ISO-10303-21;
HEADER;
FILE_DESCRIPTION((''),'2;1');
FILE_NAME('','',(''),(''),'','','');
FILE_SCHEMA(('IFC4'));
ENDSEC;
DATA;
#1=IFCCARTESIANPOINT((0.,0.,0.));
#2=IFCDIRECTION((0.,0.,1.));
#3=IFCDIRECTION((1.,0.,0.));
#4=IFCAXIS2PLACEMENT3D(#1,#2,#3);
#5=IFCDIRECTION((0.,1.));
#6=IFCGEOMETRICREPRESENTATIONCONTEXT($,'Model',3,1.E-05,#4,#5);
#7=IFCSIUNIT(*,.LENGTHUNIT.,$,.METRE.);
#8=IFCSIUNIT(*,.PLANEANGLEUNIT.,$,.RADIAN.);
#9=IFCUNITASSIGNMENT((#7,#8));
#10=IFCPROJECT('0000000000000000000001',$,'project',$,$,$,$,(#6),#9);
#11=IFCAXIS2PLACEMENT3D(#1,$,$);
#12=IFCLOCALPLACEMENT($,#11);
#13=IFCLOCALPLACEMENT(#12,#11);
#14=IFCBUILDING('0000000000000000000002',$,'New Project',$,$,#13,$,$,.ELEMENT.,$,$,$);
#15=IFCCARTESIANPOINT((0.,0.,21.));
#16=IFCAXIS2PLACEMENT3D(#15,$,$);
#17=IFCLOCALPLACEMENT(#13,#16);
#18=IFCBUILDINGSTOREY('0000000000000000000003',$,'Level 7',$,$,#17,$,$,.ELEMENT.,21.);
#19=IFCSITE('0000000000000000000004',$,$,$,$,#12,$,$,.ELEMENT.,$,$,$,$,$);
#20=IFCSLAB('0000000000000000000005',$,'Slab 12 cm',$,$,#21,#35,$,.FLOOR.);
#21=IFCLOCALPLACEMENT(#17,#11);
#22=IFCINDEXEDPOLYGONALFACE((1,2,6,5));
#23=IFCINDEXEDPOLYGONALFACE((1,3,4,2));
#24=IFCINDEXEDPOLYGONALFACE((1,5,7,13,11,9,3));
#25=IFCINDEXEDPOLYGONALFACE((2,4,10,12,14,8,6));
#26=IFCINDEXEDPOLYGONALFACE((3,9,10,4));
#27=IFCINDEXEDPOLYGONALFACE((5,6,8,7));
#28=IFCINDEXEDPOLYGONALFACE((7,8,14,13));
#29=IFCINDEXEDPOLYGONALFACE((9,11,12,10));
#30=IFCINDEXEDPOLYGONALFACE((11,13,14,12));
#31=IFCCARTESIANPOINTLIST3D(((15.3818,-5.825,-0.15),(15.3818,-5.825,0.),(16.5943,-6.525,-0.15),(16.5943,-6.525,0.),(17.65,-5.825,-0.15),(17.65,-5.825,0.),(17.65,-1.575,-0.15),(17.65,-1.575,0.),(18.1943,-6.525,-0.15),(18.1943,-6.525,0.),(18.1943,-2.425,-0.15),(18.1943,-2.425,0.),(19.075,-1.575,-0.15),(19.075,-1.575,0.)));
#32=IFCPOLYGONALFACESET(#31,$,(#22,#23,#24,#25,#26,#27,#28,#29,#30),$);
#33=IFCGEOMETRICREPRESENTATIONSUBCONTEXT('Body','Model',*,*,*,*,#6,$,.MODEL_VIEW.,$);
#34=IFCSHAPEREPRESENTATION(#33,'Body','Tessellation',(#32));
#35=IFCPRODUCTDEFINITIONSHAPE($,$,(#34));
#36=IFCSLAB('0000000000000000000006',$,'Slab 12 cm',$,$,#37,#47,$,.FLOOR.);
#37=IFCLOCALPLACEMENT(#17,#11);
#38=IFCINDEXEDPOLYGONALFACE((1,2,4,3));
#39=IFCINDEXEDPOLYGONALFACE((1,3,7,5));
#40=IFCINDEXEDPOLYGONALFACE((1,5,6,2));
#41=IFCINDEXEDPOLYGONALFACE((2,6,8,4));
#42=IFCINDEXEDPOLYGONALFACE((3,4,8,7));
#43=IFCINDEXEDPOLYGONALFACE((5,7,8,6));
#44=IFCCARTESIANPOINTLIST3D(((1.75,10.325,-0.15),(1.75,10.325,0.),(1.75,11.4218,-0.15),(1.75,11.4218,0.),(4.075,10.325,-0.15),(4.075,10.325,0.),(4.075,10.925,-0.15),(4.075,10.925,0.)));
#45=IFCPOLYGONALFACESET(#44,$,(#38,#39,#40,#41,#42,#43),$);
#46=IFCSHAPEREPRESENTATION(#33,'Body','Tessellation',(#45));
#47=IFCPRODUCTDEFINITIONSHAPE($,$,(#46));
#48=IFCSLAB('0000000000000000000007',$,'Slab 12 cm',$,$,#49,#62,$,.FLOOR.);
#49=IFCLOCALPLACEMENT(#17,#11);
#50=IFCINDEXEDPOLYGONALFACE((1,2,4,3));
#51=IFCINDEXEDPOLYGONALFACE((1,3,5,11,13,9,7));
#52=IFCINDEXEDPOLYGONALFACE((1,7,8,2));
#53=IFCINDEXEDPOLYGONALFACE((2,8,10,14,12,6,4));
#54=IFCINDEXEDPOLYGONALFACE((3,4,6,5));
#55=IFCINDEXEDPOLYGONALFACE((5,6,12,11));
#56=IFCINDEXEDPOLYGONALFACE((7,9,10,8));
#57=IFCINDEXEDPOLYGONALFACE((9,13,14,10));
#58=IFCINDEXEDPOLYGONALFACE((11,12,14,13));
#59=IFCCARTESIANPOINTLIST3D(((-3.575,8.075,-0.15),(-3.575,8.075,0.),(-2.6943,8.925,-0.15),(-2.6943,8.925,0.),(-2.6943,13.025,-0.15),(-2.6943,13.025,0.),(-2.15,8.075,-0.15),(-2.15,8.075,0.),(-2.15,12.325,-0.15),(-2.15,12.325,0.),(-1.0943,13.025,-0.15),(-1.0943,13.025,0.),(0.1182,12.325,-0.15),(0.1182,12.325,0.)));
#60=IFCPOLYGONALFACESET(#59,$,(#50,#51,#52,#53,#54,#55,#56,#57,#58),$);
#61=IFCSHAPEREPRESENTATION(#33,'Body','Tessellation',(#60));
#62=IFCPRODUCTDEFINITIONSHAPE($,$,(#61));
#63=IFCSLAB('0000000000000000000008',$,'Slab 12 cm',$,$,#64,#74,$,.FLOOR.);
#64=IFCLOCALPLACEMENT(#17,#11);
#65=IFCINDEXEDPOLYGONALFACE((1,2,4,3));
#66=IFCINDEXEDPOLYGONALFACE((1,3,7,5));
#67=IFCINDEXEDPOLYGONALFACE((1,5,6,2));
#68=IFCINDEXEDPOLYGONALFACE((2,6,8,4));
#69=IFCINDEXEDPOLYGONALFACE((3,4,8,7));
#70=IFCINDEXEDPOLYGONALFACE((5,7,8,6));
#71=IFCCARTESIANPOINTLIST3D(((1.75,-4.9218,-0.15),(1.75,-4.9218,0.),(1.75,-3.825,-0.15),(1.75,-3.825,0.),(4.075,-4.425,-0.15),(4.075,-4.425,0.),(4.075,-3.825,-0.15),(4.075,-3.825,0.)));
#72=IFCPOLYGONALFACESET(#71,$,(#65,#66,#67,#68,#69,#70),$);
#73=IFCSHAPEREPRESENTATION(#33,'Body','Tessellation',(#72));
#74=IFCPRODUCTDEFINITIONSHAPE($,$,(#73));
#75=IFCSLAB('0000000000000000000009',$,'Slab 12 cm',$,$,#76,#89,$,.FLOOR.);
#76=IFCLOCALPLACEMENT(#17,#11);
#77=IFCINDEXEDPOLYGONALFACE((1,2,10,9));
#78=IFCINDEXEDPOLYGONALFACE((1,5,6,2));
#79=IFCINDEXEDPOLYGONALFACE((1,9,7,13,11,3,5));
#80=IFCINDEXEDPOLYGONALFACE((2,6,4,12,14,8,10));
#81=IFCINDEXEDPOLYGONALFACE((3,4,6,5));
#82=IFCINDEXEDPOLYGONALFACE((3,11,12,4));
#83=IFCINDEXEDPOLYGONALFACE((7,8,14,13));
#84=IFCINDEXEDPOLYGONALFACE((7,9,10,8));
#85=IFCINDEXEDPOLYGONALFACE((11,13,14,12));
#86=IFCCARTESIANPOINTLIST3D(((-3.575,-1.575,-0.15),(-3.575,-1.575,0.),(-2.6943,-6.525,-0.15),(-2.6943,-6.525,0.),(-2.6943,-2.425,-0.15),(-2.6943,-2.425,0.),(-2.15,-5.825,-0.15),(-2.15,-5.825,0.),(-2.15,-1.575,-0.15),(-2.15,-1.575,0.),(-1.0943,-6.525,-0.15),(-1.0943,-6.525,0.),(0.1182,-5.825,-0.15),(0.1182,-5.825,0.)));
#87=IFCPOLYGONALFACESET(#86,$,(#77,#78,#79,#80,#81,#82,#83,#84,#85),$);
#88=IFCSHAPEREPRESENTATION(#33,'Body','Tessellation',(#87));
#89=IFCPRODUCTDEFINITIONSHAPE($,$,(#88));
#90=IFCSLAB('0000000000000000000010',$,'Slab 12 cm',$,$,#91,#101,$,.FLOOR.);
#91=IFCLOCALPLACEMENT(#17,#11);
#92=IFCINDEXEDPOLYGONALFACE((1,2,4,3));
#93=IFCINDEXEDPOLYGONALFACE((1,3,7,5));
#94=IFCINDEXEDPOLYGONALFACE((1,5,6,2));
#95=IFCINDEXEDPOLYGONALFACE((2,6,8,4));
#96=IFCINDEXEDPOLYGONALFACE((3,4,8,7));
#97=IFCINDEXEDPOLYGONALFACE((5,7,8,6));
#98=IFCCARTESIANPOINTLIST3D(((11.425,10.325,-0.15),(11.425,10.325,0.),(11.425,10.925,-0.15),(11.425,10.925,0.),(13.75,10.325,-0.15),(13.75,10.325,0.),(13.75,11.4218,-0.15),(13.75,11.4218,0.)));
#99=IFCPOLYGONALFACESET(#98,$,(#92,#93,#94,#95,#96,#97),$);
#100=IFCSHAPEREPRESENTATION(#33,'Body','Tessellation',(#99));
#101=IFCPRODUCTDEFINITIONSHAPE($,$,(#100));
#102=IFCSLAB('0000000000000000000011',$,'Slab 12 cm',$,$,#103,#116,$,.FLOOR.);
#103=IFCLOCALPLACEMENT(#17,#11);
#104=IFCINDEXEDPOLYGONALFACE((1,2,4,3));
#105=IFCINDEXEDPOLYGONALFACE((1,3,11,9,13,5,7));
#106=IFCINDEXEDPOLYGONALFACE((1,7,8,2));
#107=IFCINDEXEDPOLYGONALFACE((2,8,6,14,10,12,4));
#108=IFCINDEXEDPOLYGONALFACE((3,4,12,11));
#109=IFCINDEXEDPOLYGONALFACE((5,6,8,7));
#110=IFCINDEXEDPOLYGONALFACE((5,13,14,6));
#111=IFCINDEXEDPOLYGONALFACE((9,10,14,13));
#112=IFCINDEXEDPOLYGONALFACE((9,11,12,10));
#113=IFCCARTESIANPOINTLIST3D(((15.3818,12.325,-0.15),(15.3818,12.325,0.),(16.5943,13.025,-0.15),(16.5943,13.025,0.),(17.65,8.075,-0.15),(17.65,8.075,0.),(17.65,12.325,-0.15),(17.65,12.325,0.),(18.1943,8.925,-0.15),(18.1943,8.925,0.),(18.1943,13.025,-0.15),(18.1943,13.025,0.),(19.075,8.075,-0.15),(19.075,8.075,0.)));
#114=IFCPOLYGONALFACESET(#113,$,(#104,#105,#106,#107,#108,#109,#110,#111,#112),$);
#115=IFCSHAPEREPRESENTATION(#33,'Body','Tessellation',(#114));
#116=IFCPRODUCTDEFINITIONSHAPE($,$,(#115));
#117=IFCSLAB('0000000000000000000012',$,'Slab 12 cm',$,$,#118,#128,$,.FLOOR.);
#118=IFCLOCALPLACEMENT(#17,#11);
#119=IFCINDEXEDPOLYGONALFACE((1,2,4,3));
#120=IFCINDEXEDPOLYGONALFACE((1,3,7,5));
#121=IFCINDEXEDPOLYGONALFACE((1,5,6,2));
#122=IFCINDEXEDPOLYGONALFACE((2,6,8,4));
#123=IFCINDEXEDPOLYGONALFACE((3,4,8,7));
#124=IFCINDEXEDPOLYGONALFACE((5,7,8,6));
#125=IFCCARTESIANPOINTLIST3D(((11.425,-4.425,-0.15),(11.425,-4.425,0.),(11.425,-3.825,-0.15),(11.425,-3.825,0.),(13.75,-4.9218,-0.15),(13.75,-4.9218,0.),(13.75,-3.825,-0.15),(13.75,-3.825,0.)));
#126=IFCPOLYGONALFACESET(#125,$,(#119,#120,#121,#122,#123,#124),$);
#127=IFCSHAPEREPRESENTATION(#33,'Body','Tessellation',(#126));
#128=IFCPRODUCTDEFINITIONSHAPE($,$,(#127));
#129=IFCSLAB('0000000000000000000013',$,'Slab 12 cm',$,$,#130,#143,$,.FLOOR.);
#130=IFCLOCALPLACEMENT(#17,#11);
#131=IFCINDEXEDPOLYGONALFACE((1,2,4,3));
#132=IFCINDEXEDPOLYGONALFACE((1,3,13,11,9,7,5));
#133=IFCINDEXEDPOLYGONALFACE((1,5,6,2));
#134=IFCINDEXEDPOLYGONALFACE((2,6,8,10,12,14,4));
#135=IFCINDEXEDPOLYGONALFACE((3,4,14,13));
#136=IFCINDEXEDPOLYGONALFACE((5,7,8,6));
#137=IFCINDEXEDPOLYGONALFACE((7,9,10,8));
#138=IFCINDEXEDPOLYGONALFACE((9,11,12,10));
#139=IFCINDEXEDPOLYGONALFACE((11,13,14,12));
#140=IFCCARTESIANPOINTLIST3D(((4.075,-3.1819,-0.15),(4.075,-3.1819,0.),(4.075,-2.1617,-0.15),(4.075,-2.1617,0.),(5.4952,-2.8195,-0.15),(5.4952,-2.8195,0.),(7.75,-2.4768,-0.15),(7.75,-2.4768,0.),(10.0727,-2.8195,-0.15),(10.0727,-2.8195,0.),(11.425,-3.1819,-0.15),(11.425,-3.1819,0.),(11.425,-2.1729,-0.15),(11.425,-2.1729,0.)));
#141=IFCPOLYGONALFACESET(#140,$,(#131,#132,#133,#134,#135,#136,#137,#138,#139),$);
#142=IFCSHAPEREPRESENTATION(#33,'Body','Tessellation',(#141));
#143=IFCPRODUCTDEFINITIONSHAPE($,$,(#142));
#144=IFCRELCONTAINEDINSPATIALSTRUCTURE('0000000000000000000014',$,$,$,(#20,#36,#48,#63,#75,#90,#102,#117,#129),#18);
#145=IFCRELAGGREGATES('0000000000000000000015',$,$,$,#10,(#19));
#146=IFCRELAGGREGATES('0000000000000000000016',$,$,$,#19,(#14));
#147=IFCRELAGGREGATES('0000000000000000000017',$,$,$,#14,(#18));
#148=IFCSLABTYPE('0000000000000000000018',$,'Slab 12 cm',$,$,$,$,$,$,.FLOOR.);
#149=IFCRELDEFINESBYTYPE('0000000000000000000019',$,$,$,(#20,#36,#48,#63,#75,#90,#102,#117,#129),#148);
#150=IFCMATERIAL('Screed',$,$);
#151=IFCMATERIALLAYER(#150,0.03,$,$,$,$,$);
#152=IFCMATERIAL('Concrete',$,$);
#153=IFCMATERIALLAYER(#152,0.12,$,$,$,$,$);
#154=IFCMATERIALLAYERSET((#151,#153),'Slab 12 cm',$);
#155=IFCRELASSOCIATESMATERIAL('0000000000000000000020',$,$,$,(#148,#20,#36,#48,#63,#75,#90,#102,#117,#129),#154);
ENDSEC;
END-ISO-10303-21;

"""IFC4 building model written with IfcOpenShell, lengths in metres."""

from ifc_helpers import new_model, si_unit, direction, frame, origin, origin_with_axes, place, context, subcontext, project, spatial, polyline, outline, extrude, material, layer, layer_set, layer_usage, type_object, element, save


model = new_model("IFC4")

# Units and contexts
model_context = context("Model", 3, precision=1e-05, world=origin_with_axes(), true_north=direction((0.0, 1.0)))
body_context = subcontext(model_context, "Body", "Model", "MODEL_VIEW")
ifc_project = project(units=[si_unit("LENGTHUNIT", "METRE"), si_unit("PLANEANGLEUNIT", "RADIAN")], contexts=[model_context])

# Site, building, storey
site_placement = place(None, origin())
site = spatial("IfcSite", under=ifc_project, at=site_placement, CompositionType="ELEMENT")
building_placement = place(site_placement, origin())
building = spatial("IfcBuilding", under=site, at=building_placement, Name="New Project", CompositionType="ELEMENT")
storey_placement = place(building_placement, frame((0.0, 0.0, 21.0)))
storey = spatial("IfcBuildingStorey", under=building, at=storey_placement, Name="Level 7", CompositionType="ELEMENT", Elevation=21.0)

# Slabs
ifc_material_1 = material(Name="Screed")
ifc_layer_1 = layer(ifc_material_1, 0.03)
ifc_material_2 = material(Name="Concrete")
ifc_layer_2 = layer(ifc_material_2, 0.12)
ifc_layer_set_1 = layer_set([ifc_layer_1, ifc_layer_2], Name="Slab 12 cm")
ifc_layer_usage_1 = layer_usage(ifc_layer_set_1, "AXIS3", "NEGATIVE", 0.15)
slab_type = type_object("IfcSlabType", Name="Slab 12 cm", PredefinedType="FLOOR", material=ifc_layer_set_1)
slab_1_placement = place(storey_placement, frame((0.0, 0.0, -0.15)))
element("IfcSlab", 1, at=slab_1_placement, inside=storey, type_object=slab_type, material=ifc_layer_usage_1, Name="Slab 12 cm", PredefinedType="FLOOR", context=body_context, shape_type="SweptSolid", body=[
    extrude(outline(polyline([(15.3818, -5.825), (16.5943, -6.525), (18.1943, -6.525), (18.1943, -2.425), (19.075, -1.575), (17.65, -1.575), (17.65, -5.825), (15.3818, -5.825)])), origin(), (0.0, 0.0, 1.0), 0.15),
])
slab_2_placement = place(storey_placement, frame((0.0, 0.0, -0.15)))
element("IfcSlab", 2, at=slab_2_placement, inside=storey, type_object=slab_type, material=ifc_layer_usage_1, Name="Slab 12 cm", PredefinedType="FLOOR", context=body_context, shape_type="SweptSolid", body=[
    extrude(outline(polyline([(4.075, 10.325), (4.075, 10.925), (1.75, 11.4218), (1.75, 10.325), (4.075, 10.325)])), origin(), (0.0, 0.0, 1.0), 0.15),
])
slab_3_placement = place(storey_placement, frame((0.0, 0.0, -0.15)))
element("IfcSlab", 3, at=slab_3_placement, inside=storey, type_object=slab_type, material=ifc_layer_usage_1, Name="Slab 12 cm", PredefinedType="FLOOR", context=body_context, shape_type="SweptSolid", body=[
    extrude(outline(polyline([(0.1182, 12.325), (-1.0943, 13.025), (-2.6943, 13.025), (-2.6943, 8.925), (-3.575, 8.075), (-2.15, 8.075), (-2.15, 12.325), (0.1182, 12.325)])), origin(), (0.0, 0.0, 1.0), 0.15),
])
slab_4_placement = place(storey_placement, frame((0.0, 0.0, -0.15)))
element("IfcSlab", 4, at=slab_4_placement, inside=storey, type_object=slab_type, material=ifc_layer_usage_1, Name="Slab 12 cm", PredefinedType="FLOOR", context=body_context, shape_type="SweptSolid", body=[
    extrude(outline(polyline([(1.75, -3.825), (1.75, -4.9218), (4.075, -4.425), (4.075, -3.825), (1.75, -3.825)])), origin(), (0.0, 0.0, 1.0), 0.15),
])
slab_5_placement = place(storey_placement, frame((0.0, 0.0, -0.15)))
element("IfcSlab", 5, at=slab_5_placement, inside=storey, type_object=slab_type, material=ifc_layer_usage_1, Name="Slab 12 cm", PredefinedType="FLOOR", context=body_context, shape_type="SweptSolid", body=[
    extrude(outline(polyline([(-2.15, -5.825), (-2.15, -1.575), (-3.575, -1.575), (-2.6943, -2.425), (-2.6943, -6.525), (-1.0943, -6.525), (0.1182, -5.825), (-2.15, -5.825)])), origin(), (0.0, 0.0, 1.0), 0.15),
])
slab_6_placement = place(storey_placement, frame((0.0, 0.0, -0.15)))
element("IfcSlab", 6, at=slab_6_placement, inside=storey, type_object=slab_type, material=ifc_layer_usage_1, Name="Slab 12 cm", PredefinedType="FLOOR", context=body_context, shape_type="SweptSolid", body=[
    extrude(outline(polyline([(13.75, 10.325), (13.75, 11.4218), (11.425, 10.925), (11.425, 10.325), (13.75, 10.325)])), origin(), (0.0, 0.0, 1.0), 0.15),
])
slab_7_placement = place(storey_placement, frame((0.0, 0.0, -0.15)))
element("IfcSlab", 7, at=slab_7_placement, inside=storey, type_object=slab_type, material=ifc_layer_usage_1, Name="Slab 12 cm", PredefinedType="FLOOR", context=body_context, shape_type="SweptSolid", body=[
    extrude(outline(polyline([(17.65, 12.325), (17.65, 8.075), (19.075, 8.075), (18.1943, 8.925), (18.1943, 13.025), (16.5943, 13.025), (15.3818, 12.325), (17.65, 12.325)])), origin(), (0.0, 0.0, 1.0), 0.15),
])
slab_8_placement = place(storey_placement, frame((0.0, 0.0, -0.15)))
element("IfcSlab", 8, at=slab_8_placement, inside=storey, type_object=slab_type, material=ifc_layer_usage_1, Name="Slab 12 cm", PredefinedType="FLOOR", context=body_context, shape_type="SweptSolid", body=[
    extrude(outline(polyline([(11.425, -3.825), (11.425, -4.425), (13.75, -4.9218), (13.75, -3.825), (11.425, -3.825)])), origin(), (0.0, 0.0, 1.0), 0.15),
])
slab_9_placement = place(storey_placement, frame((0.0, 0.0, -0.15)))
element("IfcSlab", 9, at=slab_9_placement, inside=storey, type_object=slab_type, material=ifc_layer_usage_1, Name="Slab 12 cm", PredefinedType="FLOOR", context=body_context, shape_type="SweptSolid", body=[
    extrude(outline(polyline([(4.075, -3.1819), (5.4952, -2.8195), (7.75, -2.4768), (10.0727, -2.8195), (11.425, -3.1819), (11.425, -2.1729), (4.075, -2.1617), (4.075, -3.1819)])), origin(), (0.0, 0.0, 1.0), 0.15),
])

save(model, "model.ifc")
